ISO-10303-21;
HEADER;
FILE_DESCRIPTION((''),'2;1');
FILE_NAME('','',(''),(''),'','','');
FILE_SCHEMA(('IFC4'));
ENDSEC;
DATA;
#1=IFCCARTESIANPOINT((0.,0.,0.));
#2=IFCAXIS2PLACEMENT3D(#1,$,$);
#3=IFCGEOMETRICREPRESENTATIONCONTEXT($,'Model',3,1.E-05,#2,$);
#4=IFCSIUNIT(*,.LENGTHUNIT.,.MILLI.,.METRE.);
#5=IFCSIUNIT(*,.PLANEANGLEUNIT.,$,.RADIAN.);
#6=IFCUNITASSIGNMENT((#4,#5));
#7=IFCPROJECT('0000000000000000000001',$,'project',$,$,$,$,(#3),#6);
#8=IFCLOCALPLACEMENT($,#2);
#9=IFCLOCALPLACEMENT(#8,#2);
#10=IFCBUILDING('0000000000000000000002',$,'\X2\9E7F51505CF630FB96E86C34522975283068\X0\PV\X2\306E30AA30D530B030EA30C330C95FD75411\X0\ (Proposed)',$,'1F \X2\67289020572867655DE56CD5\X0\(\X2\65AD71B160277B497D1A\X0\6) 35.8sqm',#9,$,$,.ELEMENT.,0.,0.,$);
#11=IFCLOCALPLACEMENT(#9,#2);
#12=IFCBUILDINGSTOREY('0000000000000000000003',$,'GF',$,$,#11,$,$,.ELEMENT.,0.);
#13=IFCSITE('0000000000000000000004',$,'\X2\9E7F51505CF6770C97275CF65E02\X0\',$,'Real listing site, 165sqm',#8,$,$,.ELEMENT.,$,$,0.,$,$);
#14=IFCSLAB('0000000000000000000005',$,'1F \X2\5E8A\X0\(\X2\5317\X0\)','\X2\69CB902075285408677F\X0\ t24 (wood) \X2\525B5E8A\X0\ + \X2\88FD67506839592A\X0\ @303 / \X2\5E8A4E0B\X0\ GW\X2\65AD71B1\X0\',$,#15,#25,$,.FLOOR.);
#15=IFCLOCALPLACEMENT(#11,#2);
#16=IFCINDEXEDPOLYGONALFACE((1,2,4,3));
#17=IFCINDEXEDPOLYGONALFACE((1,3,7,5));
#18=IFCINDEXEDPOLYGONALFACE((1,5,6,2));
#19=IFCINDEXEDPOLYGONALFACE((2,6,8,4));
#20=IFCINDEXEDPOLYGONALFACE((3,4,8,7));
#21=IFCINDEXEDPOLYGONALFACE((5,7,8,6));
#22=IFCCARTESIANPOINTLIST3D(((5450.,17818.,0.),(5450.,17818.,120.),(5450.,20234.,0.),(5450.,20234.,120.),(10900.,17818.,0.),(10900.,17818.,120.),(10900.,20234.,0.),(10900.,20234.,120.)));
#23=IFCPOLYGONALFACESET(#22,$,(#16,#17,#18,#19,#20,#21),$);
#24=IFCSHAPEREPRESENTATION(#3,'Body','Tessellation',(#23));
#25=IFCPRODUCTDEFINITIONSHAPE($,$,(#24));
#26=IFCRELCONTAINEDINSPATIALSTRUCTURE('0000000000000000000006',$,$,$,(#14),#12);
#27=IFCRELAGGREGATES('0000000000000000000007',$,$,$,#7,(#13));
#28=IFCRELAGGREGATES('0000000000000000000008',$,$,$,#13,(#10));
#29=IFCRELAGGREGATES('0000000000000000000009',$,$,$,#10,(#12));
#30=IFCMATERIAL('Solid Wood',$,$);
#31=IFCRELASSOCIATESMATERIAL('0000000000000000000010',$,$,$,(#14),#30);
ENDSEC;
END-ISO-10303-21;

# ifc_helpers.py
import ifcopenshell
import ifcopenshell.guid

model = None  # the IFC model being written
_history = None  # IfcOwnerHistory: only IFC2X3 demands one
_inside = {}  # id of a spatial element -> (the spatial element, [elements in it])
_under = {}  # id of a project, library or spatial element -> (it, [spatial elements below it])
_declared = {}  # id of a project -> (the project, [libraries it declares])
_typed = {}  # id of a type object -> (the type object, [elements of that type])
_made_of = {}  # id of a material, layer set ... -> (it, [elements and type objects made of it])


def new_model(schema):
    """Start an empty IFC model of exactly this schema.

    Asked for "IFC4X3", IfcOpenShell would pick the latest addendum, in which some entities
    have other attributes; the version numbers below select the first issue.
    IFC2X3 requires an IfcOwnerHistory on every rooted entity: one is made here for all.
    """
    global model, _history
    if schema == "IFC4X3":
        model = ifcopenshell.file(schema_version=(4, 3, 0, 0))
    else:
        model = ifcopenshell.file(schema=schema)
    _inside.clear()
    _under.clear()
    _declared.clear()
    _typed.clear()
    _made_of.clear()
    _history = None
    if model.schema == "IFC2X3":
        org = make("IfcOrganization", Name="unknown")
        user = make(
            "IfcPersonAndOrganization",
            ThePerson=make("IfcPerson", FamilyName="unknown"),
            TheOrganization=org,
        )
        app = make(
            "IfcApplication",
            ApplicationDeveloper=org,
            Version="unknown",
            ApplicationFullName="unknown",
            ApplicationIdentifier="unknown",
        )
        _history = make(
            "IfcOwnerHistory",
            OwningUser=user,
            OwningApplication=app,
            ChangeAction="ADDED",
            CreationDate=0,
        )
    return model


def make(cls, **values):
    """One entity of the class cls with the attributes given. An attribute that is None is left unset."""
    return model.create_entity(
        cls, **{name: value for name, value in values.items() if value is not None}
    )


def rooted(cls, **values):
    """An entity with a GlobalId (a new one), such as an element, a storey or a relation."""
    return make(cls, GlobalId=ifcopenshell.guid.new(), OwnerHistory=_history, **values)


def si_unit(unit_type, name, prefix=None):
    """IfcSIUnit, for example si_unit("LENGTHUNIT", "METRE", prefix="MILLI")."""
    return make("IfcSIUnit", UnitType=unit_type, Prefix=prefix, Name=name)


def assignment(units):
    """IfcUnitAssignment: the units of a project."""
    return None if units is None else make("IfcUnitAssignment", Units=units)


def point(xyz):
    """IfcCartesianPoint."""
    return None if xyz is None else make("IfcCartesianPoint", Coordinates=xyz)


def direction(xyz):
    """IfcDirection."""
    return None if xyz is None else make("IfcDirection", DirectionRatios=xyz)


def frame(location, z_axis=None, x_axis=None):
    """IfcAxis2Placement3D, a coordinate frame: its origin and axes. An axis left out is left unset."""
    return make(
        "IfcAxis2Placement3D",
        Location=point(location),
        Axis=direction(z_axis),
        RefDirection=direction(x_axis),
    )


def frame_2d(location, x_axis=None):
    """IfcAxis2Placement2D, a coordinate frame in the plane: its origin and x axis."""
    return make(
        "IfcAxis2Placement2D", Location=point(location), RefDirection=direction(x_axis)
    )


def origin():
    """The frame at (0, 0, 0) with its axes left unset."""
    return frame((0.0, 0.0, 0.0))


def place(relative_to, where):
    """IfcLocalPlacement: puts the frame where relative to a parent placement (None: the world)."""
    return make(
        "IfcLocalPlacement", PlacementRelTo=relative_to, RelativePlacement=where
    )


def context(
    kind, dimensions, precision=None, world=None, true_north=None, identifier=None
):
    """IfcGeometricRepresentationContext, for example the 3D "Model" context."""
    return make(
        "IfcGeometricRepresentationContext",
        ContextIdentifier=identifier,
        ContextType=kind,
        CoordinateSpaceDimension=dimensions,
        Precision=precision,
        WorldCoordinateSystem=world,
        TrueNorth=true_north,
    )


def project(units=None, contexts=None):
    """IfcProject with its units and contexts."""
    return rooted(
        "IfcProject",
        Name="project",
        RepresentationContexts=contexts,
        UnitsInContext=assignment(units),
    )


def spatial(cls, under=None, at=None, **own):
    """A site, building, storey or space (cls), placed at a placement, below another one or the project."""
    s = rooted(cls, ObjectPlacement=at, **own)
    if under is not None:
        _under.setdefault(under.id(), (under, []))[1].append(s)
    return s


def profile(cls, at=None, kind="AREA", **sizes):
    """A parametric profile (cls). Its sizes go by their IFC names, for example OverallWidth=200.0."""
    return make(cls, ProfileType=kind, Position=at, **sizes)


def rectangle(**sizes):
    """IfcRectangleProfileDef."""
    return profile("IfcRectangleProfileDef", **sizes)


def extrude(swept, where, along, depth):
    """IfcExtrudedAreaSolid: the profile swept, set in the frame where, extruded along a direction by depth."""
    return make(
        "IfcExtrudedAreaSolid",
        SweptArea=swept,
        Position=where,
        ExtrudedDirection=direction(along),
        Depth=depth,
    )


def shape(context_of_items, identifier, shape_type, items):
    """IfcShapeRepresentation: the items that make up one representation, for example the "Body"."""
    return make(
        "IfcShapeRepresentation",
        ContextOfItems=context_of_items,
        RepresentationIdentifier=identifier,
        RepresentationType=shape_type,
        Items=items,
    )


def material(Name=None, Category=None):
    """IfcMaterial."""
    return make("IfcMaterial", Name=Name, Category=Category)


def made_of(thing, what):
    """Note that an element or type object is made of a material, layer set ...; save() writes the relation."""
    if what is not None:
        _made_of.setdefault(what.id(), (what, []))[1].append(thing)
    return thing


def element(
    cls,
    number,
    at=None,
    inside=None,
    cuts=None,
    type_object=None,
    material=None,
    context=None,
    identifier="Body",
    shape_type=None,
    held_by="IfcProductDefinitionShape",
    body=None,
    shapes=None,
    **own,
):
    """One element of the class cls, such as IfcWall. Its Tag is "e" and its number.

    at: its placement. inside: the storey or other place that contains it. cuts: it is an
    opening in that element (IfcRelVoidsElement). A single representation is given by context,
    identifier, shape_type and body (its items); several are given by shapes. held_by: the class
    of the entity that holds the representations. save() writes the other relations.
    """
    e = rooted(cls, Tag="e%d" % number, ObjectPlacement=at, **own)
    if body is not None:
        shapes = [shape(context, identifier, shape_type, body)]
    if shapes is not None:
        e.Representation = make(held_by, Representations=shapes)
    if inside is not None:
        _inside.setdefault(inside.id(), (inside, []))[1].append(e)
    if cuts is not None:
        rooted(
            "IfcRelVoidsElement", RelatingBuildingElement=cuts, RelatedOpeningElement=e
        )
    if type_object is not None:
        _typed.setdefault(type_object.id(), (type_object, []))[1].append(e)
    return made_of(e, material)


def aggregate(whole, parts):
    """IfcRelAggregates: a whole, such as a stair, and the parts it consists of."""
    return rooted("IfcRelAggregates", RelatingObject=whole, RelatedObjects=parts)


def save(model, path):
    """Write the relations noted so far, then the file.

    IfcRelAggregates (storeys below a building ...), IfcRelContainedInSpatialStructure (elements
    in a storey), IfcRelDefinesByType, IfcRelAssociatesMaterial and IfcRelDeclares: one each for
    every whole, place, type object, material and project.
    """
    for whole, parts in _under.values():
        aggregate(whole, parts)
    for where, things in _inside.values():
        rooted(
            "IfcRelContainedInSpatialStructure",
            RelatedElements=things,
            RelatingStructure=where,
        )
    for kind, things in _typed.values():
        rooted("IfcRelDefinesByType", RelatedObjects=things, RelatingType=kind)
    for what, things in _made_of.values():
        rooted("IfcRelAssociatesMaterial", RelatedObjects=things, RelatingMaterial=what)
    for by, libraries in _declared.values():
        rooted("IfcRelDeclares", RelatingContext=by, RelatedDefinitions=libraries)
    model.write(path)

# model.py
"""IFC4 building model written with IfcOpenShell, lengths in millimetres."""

from ifc_helpers import new_model, si_unit, frame, frame_2d, origin, place, context, project, spatial, rectangle, extrude, material, element, save


model = new_model("IFC4")

# Units and contexts
model_context = context("Model", 3, precision=1e-05, world=origin())
ifc_project = project(units=[si_unit("LENGTHUNIT", "METRE", prefix="MILLI"), si_unit("PLANEANGLEUNIT", "RADIAN")], contexts=[model_context])

# Site, building, storey
site_placement = place(None, origin())
site = spatial("IfcSite", under=ifc_project, at=site_placement, Name="鹿児島県霧島市", ObjectType="Real listing site, 165sqm", CompositionType="ELEMENT", RefElevation=0.0)
building_placement = place(site_placement, origin())
building = spatial("IfcBuilding", under=site, at=building_placement, Name="鹿児島・雨水利用とPVのオフグリッド志向 (Proposed)", ObjectType="1F 木造在来工法(断熱性等級6) 35.8sqm", CompositionType="ELEMENT", ElevationOfRefHeight=0.0, ElevationOfTerrain=0.0)
storey_placement = place(building_placement, origin())
storey = spatial("IfcBuildingStorey", under=building, at=storey_placement, Name="GF", CompositionType="ELEMENT", Elevation=0.0)

# Shared definitions
ifc_material_1 = material(Name="Solid Wood")

# Slab
slab_1_placement = place(storey_placement, frame((2725.0, 8909.0, 0.0)))
element("IfcSlab", 1, at=slab_1_placement, inside=storey, material=ifc_material_1, Name="1F 床(北)", Description="構造用合板 t24 (wood) 剛床 + 製材根太 @303 / 床下 GW断熱", PredefinedType="FLOOR", context=model_context, shape_type="SweptSolid", body=[
    extrude(rectangle(XDim=5450.0, YDim=2416.0, at=frame_2d((2725.0, 1208.0))), frame((2725.0, 8909.0, 0.0)), (0.0, 0.0, 1.0), 120.0),
])

save(model, "model.ifc")
